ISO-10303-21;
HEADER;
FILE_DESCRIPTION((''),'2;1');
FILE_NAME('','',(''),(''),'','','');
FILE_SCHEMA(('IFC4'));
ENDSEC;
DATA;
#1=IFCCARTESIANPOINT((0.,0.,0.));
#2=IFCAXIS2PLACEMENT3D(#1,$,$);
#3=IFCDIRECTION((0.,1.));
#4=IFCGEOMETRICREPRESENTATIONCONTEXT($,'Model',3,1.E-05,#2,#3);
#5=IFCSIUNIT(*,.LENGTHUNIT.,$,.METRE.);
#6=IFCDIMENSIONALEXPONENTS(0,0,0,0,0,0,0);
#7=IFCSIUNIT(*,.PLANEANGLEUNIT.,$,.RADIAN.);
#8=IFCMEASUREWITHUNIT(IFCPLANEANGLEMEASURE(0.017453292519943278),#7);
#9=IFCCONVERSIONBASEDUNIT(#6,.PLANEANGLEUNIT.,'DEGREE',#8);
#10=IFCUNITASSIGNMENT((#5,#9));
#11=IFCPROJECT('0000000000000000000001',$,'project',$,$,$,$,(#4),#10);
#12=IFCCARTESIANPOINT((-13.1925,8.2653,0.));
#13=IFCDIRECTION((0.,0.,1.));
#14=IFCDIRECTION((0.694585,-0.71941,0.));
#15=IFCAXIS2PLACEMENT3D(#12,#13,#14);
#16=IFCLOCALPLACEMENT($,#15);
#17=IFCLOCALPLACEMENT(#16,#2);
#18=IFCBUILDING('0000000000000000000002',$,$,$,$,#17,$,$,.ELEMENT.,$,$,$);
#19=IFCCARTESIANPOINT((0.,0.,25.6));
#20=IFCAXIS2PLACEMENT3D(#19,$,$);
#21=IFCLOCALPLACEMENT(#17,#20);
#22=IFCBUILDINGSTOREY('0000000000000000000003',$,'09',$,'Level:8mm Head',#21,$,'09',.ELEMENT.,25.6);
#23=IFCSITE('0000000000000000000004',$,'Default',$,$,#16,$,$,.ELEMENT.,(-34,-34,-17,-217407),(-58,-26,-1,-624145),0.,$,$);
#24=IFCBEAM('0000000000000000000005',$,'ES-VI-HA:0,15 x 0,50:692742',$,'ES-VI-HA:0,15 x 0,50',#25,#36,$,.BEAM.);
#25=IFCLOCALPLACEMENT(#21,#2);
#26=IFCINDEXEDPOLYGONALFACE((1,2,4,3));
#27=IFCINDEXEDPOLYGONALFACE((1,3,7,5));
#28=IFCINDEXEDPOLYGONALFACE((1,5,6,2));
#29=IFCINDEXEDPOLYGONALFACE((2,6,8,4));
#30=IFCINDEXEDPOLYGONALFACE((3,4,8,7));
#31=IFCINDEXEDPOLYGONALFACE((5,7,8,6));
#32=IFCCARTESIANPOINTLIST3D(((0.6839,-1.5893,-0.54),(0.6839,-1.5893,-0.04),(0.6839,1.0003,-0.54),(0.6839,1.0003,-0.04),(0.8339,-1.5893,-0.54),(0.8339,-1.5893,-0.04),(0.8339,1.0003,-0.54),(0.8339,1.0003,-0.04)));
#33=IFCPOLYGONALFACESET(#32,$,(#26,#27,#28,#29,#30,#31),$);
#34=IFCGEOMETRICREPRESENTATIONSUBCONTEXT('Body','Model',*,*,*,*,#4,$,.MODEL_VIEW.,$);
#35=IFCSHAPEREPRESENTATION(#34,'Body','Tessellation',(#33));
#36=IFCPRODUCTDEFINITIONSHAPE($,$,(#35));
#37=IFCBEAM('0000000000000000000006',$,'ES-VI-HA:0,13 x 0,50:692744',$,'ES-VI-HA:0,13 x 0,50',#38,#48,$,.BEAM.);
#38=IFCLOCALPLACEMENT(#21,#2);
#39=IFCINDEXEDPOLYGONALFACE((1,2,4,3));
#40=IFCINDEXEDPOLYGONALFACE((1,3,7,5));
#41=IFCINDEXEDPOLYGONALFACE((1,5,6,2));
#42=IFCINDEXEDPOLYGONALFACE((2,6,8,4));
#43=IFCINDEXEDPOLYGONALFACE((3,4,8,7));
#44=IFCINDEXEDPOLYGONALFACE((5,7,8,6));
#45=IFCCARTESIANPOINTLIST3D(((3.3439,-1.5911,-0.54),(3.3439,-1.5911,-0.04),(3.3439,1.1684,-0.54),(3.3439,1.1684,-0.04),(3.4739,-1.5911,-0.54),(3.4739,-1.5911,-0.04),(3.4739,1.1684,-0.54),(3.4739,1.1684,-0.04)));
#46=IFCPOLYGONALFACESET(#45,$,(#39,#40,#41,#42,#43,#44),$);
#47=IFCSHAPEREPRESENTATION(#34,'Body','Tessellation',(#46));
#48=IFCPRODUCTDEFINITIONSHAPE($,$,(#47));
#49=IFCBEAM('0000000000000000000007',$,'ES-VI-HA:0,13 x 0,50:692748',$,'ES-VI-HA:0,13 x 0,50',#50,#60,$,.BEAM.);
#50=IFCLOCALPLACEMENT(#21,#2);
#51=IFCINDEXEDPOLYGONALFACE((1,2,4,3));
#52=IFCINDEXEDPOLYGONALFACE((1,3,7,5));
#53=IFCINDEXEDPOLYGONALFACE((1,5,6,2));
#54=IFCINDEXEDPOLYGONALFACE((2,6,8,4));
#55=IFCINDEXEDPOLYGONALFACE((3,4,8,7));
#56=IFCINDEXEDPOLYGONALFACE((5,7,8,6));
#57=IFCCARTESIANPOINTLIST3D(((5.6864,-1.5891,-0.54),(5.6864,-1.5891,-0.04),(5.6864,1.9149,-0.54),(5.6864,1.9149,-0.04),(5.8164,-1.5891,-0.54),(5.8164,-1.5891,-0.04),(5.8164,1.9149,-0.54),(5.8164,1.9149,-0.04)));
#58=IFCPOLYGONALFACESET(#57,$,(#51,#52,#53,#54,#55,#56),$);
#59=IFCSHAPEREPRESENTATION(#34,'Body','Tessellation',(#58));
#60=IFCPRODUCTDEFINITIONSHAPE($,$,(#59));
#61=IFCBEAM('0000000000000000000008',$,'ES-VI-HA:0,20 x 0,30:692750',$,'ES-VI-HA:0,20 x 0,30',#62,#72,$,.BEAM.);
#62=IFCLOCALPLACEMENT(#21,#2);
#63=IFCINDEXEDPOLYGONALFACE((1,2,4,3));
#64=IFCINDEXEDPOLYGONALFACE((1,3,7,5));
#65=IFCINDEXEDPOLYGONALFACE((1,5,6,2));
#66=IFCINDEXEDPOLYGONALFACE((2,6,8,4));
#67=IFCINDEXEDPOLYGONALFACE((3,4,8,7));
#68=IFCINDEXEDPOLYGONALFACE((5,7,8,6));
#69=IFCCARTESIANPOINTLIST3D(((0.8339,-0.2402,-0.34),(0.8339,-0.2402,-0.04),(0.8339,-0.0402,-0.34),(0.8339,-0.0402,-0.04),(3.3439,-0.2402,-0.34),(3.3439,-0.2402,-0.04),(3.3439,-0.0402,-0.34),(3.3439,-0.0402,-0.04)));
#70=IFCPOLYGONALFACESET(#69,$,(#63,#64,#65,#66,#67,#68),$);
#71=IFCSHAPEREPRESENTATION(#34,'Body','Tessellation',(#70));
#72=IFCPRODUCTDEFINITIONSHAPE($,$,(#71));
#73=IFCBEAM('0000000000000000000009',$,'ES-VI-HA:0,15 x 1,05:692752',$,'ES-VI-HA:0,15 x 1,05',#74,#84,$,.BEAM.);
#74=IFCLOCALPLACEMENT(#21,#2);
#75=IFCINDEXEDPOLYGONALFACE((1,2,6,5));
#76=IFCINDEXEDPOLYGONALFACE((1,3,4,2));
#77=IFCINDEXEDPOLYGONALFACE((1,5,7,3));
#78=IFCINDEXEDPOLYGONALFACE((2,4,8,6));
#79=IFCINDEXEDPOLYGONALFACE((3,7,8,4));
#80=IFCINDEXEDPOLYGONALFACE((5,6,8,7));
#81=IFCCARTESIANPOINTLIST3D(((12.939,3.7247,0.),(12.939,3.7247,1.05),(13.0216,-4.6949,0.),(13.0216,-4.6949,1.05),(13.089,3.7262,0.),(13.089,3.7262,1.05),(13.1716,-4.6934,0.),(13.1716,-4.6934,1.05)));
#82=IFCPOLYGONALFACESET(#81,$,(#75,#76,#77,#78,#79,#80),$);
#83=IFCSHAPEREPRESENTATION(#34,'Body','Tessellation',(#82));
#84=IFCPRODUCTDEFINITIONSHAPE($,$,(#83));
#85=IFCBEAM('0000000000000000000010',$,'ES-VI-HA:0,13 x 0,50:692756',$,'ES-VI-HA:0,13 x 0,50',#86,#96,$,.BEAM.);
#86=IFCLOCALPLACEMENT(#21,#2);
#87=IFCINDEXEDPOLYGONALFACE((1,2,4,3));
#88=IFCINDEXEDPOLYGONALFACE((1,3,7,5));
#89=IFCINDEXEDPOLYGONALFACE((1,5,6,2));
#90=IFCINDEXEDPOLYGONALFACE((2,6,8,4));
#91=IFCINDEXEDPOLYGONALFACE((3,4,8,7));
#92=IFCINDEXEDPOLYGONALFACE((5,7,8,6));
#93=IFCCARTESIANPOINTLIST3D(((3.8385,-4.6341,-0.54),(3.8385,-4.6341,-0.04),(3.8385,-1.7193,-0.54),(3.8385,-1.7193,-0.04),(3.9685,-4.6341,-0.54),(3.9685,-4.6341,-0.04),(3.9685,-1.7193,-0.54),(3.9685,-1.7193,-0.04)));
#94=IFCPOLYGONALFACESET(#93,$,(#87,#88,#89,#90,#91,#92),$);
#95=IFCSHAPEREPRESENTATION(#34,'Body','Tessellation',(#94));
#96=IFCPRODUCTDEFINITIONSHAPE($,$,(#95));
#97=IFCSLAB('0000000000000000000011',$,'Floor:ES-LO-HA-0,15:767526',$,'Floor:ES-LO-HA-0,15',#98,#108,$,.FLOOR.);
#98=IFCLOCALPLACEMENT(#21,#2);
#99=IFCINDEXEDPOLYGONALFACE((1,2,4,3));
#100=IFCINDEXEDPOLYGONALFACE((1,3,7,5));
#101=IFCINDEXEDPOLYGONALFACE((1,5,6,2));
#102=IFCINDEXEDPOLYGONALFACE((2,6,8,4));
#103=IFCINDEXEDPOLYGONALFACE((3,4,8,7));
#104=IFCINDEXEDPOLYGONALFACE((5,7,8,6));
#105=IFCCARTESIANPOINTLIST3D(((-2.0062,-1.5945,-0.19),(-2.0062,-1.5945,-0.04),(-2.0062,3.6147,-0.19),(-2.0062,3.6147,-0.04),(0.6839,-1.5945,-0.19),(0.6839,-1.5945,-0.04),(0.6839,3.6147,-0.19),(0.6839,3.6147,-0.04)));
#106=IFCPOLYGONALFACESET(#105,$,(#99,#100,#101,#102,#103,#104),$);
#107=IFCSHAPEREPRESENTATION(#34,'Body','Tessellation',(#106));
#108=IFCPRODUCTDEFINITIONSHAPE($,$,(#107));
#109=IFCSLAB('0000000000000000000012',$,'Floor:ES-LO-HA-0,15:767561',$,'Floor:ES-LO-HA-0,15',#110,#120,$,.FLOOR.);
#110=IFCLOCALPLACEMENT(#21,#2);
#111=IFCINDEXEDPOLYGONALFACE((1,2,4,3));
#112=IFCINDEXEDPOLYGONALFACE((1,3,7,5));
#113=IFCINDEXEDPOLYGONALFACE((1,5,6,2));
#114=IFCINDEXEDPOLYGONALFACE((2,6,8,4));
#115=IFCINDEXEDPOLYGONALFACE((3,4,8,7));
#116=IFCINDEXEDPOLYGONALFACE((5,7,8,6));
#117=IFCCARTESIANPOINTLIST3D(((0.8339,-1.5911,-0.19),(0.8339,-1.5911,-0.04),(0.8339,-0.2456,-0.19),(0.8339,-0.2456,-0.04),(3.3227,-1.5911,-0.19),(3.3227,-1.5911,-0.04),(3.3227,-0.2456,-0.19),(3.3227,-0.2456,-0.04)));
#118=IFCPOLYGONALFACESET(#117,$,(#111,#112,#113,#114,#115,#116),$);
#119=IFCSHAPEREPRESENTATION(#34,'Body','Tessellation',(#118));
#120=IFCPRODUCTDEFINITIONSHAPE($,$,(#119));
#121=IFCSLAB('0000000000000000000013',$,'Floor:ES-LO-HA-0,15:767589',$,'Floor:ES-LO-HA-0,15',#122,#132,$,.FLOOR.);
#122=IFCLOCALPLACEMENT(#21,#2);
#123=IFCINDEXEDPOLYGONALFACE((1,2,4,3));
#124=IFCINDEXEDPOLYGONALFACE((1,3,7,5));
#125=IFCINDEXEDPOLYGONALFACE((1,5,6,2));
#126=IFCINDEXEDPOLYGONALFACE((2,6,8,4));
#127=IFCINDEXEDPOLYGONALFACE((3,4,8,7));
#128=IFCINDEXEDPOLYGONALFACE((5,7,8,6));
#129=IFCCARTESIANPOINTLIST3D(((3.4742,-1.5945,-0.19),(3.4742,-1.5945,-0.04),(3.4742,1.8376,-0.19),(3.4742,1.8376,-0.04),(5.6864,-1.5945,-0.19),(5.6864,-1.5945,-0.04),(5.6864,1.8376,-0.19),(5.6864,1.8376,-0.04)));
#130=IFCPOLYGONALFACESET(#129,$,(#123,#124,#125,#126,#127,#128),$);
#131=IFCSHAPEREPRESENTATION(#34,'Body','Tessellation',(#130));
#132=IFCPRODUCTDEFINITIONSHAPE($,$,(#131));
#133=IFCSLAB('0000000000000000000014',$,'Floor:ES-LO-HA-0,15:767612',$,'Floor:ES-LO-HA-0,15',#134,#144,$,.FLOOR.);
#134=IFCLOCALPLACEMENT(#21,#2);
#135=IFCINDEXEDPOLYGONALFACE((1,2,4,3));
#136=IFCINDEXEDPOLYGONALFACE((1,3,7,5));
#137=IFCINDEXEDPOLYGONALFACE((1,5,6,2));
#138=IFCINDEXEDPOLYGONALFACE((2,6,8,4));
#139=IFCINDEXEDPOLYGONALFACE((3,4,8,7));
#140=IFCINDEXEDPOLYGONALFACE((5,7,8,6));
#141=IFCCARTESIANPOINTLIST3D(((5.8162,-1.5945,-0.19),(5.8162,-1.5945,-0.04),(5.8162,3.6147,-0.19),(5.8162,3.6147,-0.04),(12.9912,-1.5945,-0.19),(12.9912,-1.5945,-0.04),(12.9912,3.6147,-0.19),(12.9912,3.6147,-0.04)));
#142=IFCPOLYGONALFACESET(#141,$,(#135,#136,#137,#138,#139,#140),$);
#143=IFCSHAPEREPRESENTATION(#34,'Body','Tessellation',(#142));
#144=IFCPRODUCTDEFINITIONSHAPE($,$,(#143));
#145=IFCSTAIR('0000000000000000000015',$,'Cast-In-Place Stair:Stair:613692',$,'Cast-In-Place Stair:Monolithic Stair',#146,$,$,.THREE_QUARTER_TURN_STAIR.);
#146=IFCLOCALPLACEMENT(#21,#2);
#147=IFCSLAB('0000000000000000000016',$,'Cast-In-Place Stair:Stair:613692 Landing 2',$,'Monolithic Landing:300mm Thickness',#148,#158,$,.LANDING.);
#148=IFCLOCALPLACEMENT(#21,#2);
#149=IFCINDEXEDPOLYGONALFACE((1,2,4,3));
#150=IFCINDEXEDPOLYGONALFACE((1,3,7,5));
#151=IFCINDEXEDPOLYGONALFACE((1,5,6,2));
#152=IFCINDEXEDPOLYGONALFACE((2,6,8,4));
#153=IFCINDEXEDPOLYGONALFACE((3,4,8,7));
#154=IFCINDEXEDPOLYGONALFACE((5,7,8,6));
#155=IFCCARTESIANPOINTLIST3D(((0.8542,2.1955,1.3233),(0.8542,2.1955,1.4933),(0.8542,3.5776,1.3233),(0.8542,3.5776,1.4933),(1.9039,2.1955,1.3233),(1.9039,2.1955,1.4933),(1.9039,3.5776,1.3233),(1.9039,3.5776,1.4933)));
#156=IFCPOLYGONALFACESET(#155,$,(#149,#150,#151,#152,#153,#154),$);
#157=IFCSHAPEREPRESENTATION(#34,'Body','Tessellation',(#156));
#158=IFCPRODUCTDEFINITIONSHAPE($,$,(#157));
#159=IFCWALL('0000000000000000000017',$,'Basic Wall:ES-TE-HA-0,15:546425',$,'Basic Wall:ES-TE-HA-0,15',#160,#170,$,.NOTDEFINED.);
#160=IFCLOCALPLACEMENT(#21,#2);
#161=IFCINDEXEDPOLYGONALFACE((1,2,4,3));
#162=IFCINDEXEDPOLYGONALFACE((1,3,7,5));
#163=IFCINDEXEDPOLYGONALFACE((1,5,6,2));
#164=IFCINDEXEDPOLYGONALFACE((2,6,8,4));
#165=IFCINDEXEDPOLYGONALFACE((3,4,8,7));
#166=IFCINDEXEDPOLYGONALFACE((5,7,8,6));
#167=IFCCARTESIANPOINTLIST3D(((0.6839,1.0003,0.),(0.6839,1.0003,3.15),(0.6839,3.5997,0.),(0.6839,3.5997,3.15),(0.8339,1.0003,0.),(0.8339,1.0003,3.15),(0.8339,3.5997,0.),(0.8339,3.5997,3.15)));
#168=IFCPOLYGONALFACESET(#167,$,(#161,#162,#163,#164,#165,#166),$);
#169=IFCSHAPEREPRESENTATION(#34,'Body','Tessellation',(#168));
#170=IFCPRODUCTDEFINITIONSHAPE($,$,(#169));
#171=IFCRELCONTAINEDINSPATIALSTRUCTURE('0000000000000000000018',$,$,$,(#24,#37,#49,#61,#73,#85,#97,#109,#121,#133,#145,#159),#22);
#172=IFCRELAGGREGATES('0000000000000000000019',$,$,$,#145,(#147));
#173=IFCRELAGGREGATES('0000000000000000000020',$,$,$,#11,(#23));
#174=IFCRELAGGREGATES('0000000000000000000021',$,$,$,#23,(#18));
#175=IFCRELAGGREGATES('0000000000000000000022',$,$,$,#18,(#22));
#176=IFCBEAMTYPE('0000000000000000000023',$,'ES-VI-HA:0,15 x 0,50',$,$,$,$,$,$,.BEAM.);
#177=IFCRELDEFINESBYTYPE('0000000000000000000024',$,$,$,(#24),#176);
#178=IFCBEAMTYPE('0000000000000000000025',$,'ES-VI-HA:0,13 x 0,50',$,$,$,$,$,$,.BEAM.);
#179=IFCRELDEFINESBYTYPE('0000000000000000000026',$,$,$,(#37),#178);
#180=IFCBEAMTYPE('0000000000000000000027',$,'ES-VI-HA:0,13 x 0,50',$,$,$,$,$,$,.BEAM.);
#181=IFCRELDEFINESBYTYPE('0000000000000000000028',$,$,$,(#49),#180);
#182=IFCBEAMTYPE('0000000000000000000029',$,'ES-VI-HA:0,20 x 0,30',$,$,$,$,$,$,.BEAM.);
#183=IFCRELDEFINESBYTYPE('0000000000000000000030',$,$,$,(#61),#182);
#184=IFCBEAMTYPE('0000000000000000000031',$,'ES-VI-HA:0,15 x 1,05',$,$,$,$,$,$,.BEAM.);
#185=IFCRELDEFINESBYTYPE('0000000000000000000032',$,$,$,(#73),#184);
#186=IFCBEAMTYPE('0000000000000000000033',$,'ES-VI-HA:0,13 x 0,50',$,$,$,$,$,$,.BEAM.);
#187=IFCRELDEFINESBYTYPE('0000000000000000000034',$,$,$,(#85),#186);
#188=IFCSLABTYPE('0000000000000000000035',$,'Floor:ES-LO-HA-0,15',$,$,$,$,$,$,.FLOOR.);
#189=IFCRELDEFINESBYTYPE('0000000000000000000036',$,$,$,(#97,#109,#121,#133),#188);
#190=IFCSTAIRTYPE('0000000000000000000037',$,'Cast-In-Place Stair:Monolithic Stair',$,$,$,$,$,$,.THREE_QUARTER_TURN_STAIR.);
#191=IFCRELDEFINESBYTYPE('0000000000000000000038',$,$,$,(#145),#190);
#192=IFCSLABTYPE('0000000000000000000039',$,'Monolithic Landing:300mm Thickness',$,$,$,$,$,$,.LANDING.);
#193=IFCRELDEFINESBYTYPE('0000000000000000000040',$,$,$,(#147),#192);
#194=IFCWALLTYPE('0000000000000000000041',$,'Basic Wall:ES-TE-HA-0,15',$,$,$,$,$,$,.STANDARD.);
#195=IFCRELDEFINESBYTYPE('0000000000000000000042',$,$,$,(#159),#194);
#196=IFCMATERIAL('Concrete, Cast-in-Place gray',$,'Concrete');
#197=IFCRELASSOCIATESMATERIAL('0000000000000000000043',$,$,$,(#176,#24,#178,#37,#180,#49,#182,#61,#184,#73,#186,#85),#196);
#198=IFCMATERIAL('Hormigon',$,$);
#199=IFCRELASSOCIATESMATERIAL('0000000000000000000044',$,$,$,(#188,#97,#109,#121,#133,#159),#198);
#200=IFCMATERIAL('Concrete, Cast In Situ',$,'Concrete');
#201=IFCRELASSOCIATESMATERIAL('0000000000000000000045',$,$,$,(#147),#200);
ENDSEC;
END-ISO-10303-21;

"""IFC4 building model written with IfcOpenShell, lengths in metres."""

from ifc_helpers import new_model, entity, si_unit, converted_unit, direction, frame, origin, place, context, subcontext, project, spatial, indexed_curve, outline, extrude, source, transform, mapped, material, type_object, type_shapes, element, aggregate, save


model = new_model("IFC4")

# Units and contexts
model_context = context("Model", 3, precision=1e-05, world=origin(), true_north=direction((0.0, 1.0)))
body_context = subcontext(model_context, "Body", "Model", "MODEL_VIEW")
ifc_project = project(units=[si_unit("LENGTHUNIT", "METRE"), converted_unit("PLANEANGLEUNIT", "DEGREE", entity("IfcPlaneAngleMeasure", 0.017453292519943278), si_unit("PLANEANGLEUNIT", "RADIAN"), dimensions=[0, 0, 0, 0, 0, 0, 0])], contexts=[model_context])

# Site, building, storey
site_placement = place(None, frame((-13.1925, 8.2653, 0.0), z_axis=(0.0, 0.0, 1.0), x_axis=(0.694585, -0.71941, 0.0)))
site = spatial("IfcSite", under=ifc_project, at=site_placement, Name="Default", CompositionType="ELEMENT", RefLatitude=(-34, -34, -17, -217407), RefLongitude=(-58, -26, -1, -624145), RefElevation=0.0)
building_placement = place(site_placement, origin())
building = spatial("IfcBuilding", under=site, at=building_placement, CompositionType="ELEMENT")
storey_placement = place(building_placement, frame((0.0, 0.0, 25.6)))
storey = spatial("IfcBuildingStorey", under=building, at=storey_placement, Name="09", ObjectType="Level:8mm Head", LongName="09", CompositionType="ELEMENT", Elevation=25.6)

# Beams
ifc_material_1 = material(Name="Concrete, Cast-in-Place gray", Category="Concrete")
beam_type_1 = type_object("IfcBeamType", Name="ES-VI-HA:0,15 x 0,50", PredefinedType="BEAM", material=ifc_material_1)
shared_shape_1 = source(origin(), body_context, "Body", "SweptSolid", [
    extrude(outline(indexed_curve([(-0.075, -0.25), (0.075, -0.25), (0.075, 0.25), (-0.075, 0.25), (-0.075, -0.25)], self_intersect=False)), frame((0.7589, -1.5893, 25.31), z_axis=(0.0, 1.0, 0.0), x_axis=(-1.0, 0.0, 0.0)), (0.0, 0.0, 1.0), 2.5896),
])
type_shapes(beam_type_1, [shared_shape_1])
beam_1_placement = place(storey_placement, frame((0.0, 0.0, -25.6)))
element("IfcBeam", 1, at=beam_1_placement, inside=storey, type_object=beam_type_1, material=ifc_material_1, Name="ES-VI-HA:0,15 x 0,50:692742", ObjectType="ES-VI-HA:0,15 x 0,50", PredefinedType="BEAM", context=body_context, shape_type="MappedRepresentation", body=[
    mapped(shared_shape_1, transform((0.0, 0.0, 0.0), scale=1.0)),
])
beam_type_2 = type_object("IfcBeamType", Name="ES-VI-HA:0,13 x 0,50", PredefinedType="BEAM", material=ifc_material_1)
shared_shape_2 = source(origin(), body_context, "Body", "SweptSolid", [
    extrude(outline(indexed_curve([(-0.065, -0.25), (0.065, -0.25), (0.065, 0.25), (-0.065, 0.25), (-0.065, -0.25)], self_intersect=False)), frame((3.4089, -1.5911, 25.31), z_axis=(0.0, 1.0, 0.0), x_axis=(-1.0, 0.0, 0.0)), (0.0, 0.0, 1.0), 2.7595),
])
type_shapes(beam_type_2, [shared_shape_2])
beam_2_placement = place(storey_placement, frame((0.0, 0.0, -25.6)))
element("IfcBeam", 2, at=beam_2_placement, inside=storey, type_object=beam_type_2, material=ifc_material_1, Name="ES-VI-HA:0,13 x 0,50:692744", ObjectType="ES-VI-HA:0,13 x 0,50", PredefinedType="BEAM", context=body_context, shape_type="MappedRepresentation", body=[
    mapped(shared_shape_2, transform((0.0, 0.0, 0.0), scale=1.0)),
])
beam_type_3 = type_object("IfcBeamType", Name="ES-VI-HA:0,13 x 0,50", PredefinedType="BEAM", material=ifc_material_1)
shared_shape_3 = source(origin(), body_context, "Body", "SweptSolid", [
    extrude(outline(indexed_curve([(-0.065, -0.25), (0.065, -0.25), (0.065, 0.25), (-0.065, 0.25), (-0.065, -0.25)], self_intersect=False)), frame((5.7514, -1.5891, 25.31), z_axis=(0.0, 1.0, 0.0), x_axis=(-1.0, 0.0, 0.0)), (0.0, 0.0, 1.0), 3.5039),
])
type_shapes(beam_type_3, [shared_shape_3])
beam_3_placement = place(storey_placement, frame((0.0, 0.0, -25.6)))
element("IfcBeam", 3, at=beam_3_placement, inside=storey, type_object=beam_type_3, material=ifc_material_1, Name="ES-VI-HA:0,13 x 0,50:692748", ObjectType="ES-VI-HA:0,13 x 0,50", PredefinedType="BEAM", context=body_context, shape_type="MappedRepresentation", body=[
    mapped(shared_shape_3, transform((0.0, 0.0, 0.0), scale=1.0)),
])
beam_type_4 = type_object("IfcBeamType", Name="ES-VI-HA:0,20 x 0,30", PredefinedType="BEAM", material=ifc_material_1)
shared_shape_4 = source(origin(), body_context, "Body", "SweptSolid", [
    extrude(outline(indexed_curve([(-0.15, -0.1), (0.15, -0.1), (0.15, 0.1), (-0.15, 0.1), (-0.15, -0.1)], self_intersect=False)), frame((0.8339, -0.1402, 25.41), z_axis=(1.0, 0.0, 0.0), x_axis=(0.0, 0.0, -1.0)), (0.0, 0.0, 1.0), 2.51),
])
type_shapes(beam_type_4, [shared_shape_4])
beam_4_placement = place(storey_placement, frame((0.0, 0.0, -25.6)))
element("IfcBeam", 4, at=beam_4_placement, inside=storey, type_object=beam_type_4, material=ifc_material_1, Name="ES-VI-HA:0,20 x 0,30:692750", ObjectType="ES-VI-HA:0,20 x 0,30", PredefinedType="BEAM", context=body_context, shape_type="MappedRepresentation", body=[
    mapped(shared_shape_4, transform((0.0, 0.0, 0.0), scale=1.0)),
])
beam_type_5 = type_object("IfcBeamType", Name="ES-VI-HA:0,15 x 1,05", PredefinedType="BEAM", material=ifc_material_1)
shared_shape_5 = source(origin(), body_context, "Body", "SweptSolid", [
    extrude(outline(indexed_curve([(-0.525, -0.075), (0.525, -0.075), (0.525, 0.075), (-0.525, 0.075), (-0.525, -0.075)], self_intersect=False)), frame((13.014, 3.7254, 26.125), z_axis=(0.009814, -0.999952, 0.0), x_axis=(0.0, 0.0, -1.0)), (0.0, 0.0, 1.0), 8.42),
])
type_shapes(beam_type_5, [shared_shape_5])
beam_5_placement = place(storey_placement, frame((0.0, 0.0, -25.6)))
element("IfcBeam", 5, at=beam_5_placement, inside=storey, type_object=beam_type_5, material=ifc_material_1, Name="ES-VI-HA:0,15 x 1,05:692752", ObjectType="ES-VI-HA:0,15 x 1,05", PredefinedType="BEAM", context=body_context, shape_type="MappedRepresentation", body=[
    mapped(shared_shape_5, transform((0.0, 0.0, 0.0), scale=1.0)),
])
beam_type_6 = type_object("IfcBeamType", Name="ES-VI-HA:0,13 x 0,50", PredefinedType="BEAM", material=ifc_material_1)
shared_shape_6 = source(origin(), body_context, "Body", "SweptSolid", [
    extrude(outline(indexed_curve([(-0.065, -0.25), (0.065, -0.25), (0.065, 0.25), (-0.065, 0.25), (-0.065, -0.25)], self_intersect=False)), frame((3.9035, -4.6341, 25.31), z_axis=(0.0, 1.0, 0.0), x_axis=(-1.0, 0.0, 0.0)), (0.0, 0.0, 1.0), 2.9148),
])
type_shapes(beam_type_6, [shared_shape_6])
beam_6_placement = place(storey_placement, frame((0.0, 0.0, -25.6)))
element("IfcBeam", 6, at=beam_6_placement, inside=storey, type_object=beam_type_6, material=ifc_material_1, Name="ES-VI-HA:0,13 x 0,50:692756", ObjectType="ES-VI-HA:0,13 x 0,50", PredefinedType="BEAM", context=body_context, shape_type="MappedRepresentation", body=[
    mapped(shared_shape_6, transform((0.0, 0.0, 0.0), scale=1.0)),
])

# Shared definitions
ifc_material_2 = material(Name="Hormigon")
slab_type_1 = type_object("IfcSlabType", Name="Floor:ES-LO-HA-0,15", PredefinedType="FLOOR", material=ifc_material_2)

# Slabs
slab_1_placement = place(storey_placement, origin())
element("IfcSlab", 7, at=slab_1_placement, inside=storey, type_object=slab_type_1, material=ifc_material_2, Name="Floor:ES-LO-HA-0,15:767526", ObjectType="Floor:ES-LO-HA-0,15", PredefinedType="FLOOR", context=body_context, shape_type="SweptSolid", body=[
    extrude(outline(indexed_curve([(-2.6046, -1.3451), (2.6046, -1.3451), (2.6046, 1.3451), (-2.6046, 1.3451), (-2.6046, -1.3451)], self_intersect=False)), frame((-0.6611, 1.0101, -0.04), z_axis=(0.0, 0.0, -1.0), x_axis=(0.0, 1.0, 0.0)), (0.0, 0.0, 1.0), 0.15),
])
slab_2_placement = place(storey_placement, origin())
element("IfcSlab", 8, at=slab_2_placement, inside=storey, type_object=slab_type_1, material=ifc_material_2, Name="Floor:ES-LO-HA-0,15:767561", ObjectType="Floor:ES-LO-HA-0,15", PredefinedType="FLOOR", context=body_context, shape_type="SweptSolid", body=[
    extrude(outline(indexed_curve([(-0.6727, -1.2444), (0.6727, -1.2444), (0.6727, 1.2444), (-0.6727, 1.2444), (-0.6727, -1.2444)], self_intersect=False)), frame((2.0783, -0.9183, -0.04), z_axis=(0.0, 0.0, -1.0), x_axis=(0.0, 1.0, 0.0)), (0.0, 0.0, 1.0), 0.15),
])
slab_3_placement = place(storey_placement, origin())
element("IfcSlab", 9, at=slab_3_placement, inside=storey, type_object=slab_type_1, material=ifc_material_2, Name="Floor:ES-LO-HA-0,15:767589", ObjectType="Floor:ES-LO-HA-0,15", PredefinedType="FLOOR", context=body_context, shape_type="SweptSolid", body=[
    extrude(outline(indexed_curve([(-1.7161, -1.1061), (1.7161, -1.1061), (1.7161, 1.1061), (-1.7161, 1.1061), (-1.7161, -1.1061)], self_intersect=False)), frame((4.5803, 0.1216, -0.04), z_axis=(0.0, 0.0, -1.0), x_axis=(0.0, 1.0, 0.0)), (0.0, 0.0, 1.0), 0.15),
])
slab_4_placement = place(storey_placement, origin())
element("IfcSlab", 10, at=slab_4_placement, inside=storey, type_object=slab_type_1, material=ifc_material_2, Name="Floor:ES-LO-HA-0,15:767612", ObjectType="Floor:ES-LO-HA-0,15", PredefinedType="FLOOR", context=body_context, shape_type="SweptSolid", body=[
    extrude(outline(indexed_curve([(-2.6046, -3.5875), (2.6046, -3.5875), (2.6046, 3.5875), (-2.6046, 3.5875), (-2.6046, -3.5875)], self_intersect=False)), frame((9.4037, 1.0101, -0.04), z_axis=(0.0, 0.0, -1.0), x_axis=(0.0, 1.0, 0.0)), (0.0, 0.0, 1.0), 0.15),
])

# Stair, slab
stair_type = type_object("IfcStairType", Name="Cast-In-Place Stair:Monolithic Stair", PredefinedType="THREE_QUARTER_TURN_STAIR")
stair_placement = place(storey_placement, origin())
stair = element("IfcStair", 11, at=stair_placement, inside=storey, type_object=stair_type, Name="Cast-In-Place Stair:Stair:613692", ObjectType="Cast-In-Place Stair:Monolithic Stair", PredefinedType="THREE_QUARTER_TURN_STAIR")
ifc_material_3 = material(Name="Concrete, Cast In Situ", Category="Concrete")
slab_type_2 = type_object("IfcSlabType", Name="Monolithic Landing:300mm Thickness", PredefinedType="LANDING")
slab_5_placement = place(stair_placement, origin())
slab_5 = element("IfcSlab", 12, at=slab_5_placement, type_object=slab_type_2, material=ifc_material_3, Name="Cast-In-Place Stair:Stair:613692 Landing 2", ObjectType="Monolithic Landing:300mm Thickness", PredefinedType="LANDING", context=body_context, shape_type="SweptSolid", body=[
    extrude(outline(indexed_curve([(-0.6911, -0.5249), (0.6911, -0.5249), (0.6911, 0.5249), (-0.6911, 0.5249), (-0.6911, -0.5249)], self_intersect=False)), frame((1.379, 2.8866, 1.3233), z_axis=(0.0, 0.0, 1.0), x_axis=(0.0, 1.0, 0.0)), (0.0, 0.0, 1.0), 0.17),
])
aggregate(stair, [slab_5])

# Wall
wall_type_1 = type_object("IfcWallType", Name="Basic Wall:ES-TE-HA-0,15", PredefinedType="STANDARD")
wall_1_placement = place(storey_placement, frame((0.7589, 1.0003, 0.0), z_axis=(0.0, 0.0, 1.0), x_axis=(0.0, 1.0, 0.0)))
element("IfcWall", 13, at=wall_1_placement, inside=storey, type_object=wall_type_1, material=ifc_material_2, Name="Basic Wall:ES-TE-HA-0,15:546425", ObjectType="Basic Wall:ES-TE-HA-0,15", PredefinedType="NOTDEFINED", context=body_context, shape_type="SweptSolid", body=[
    extrude(outline(indexed_curve([(2.5994, 0.075), (0.0, 0.075), (0.0, -0.075), (2.5994, -0.075), (2.5994, 0.075)], self_intersect=False)), origin(), (0.0, 0.0, 1.0), 3.15),
])

save(model, "model.ifc")
